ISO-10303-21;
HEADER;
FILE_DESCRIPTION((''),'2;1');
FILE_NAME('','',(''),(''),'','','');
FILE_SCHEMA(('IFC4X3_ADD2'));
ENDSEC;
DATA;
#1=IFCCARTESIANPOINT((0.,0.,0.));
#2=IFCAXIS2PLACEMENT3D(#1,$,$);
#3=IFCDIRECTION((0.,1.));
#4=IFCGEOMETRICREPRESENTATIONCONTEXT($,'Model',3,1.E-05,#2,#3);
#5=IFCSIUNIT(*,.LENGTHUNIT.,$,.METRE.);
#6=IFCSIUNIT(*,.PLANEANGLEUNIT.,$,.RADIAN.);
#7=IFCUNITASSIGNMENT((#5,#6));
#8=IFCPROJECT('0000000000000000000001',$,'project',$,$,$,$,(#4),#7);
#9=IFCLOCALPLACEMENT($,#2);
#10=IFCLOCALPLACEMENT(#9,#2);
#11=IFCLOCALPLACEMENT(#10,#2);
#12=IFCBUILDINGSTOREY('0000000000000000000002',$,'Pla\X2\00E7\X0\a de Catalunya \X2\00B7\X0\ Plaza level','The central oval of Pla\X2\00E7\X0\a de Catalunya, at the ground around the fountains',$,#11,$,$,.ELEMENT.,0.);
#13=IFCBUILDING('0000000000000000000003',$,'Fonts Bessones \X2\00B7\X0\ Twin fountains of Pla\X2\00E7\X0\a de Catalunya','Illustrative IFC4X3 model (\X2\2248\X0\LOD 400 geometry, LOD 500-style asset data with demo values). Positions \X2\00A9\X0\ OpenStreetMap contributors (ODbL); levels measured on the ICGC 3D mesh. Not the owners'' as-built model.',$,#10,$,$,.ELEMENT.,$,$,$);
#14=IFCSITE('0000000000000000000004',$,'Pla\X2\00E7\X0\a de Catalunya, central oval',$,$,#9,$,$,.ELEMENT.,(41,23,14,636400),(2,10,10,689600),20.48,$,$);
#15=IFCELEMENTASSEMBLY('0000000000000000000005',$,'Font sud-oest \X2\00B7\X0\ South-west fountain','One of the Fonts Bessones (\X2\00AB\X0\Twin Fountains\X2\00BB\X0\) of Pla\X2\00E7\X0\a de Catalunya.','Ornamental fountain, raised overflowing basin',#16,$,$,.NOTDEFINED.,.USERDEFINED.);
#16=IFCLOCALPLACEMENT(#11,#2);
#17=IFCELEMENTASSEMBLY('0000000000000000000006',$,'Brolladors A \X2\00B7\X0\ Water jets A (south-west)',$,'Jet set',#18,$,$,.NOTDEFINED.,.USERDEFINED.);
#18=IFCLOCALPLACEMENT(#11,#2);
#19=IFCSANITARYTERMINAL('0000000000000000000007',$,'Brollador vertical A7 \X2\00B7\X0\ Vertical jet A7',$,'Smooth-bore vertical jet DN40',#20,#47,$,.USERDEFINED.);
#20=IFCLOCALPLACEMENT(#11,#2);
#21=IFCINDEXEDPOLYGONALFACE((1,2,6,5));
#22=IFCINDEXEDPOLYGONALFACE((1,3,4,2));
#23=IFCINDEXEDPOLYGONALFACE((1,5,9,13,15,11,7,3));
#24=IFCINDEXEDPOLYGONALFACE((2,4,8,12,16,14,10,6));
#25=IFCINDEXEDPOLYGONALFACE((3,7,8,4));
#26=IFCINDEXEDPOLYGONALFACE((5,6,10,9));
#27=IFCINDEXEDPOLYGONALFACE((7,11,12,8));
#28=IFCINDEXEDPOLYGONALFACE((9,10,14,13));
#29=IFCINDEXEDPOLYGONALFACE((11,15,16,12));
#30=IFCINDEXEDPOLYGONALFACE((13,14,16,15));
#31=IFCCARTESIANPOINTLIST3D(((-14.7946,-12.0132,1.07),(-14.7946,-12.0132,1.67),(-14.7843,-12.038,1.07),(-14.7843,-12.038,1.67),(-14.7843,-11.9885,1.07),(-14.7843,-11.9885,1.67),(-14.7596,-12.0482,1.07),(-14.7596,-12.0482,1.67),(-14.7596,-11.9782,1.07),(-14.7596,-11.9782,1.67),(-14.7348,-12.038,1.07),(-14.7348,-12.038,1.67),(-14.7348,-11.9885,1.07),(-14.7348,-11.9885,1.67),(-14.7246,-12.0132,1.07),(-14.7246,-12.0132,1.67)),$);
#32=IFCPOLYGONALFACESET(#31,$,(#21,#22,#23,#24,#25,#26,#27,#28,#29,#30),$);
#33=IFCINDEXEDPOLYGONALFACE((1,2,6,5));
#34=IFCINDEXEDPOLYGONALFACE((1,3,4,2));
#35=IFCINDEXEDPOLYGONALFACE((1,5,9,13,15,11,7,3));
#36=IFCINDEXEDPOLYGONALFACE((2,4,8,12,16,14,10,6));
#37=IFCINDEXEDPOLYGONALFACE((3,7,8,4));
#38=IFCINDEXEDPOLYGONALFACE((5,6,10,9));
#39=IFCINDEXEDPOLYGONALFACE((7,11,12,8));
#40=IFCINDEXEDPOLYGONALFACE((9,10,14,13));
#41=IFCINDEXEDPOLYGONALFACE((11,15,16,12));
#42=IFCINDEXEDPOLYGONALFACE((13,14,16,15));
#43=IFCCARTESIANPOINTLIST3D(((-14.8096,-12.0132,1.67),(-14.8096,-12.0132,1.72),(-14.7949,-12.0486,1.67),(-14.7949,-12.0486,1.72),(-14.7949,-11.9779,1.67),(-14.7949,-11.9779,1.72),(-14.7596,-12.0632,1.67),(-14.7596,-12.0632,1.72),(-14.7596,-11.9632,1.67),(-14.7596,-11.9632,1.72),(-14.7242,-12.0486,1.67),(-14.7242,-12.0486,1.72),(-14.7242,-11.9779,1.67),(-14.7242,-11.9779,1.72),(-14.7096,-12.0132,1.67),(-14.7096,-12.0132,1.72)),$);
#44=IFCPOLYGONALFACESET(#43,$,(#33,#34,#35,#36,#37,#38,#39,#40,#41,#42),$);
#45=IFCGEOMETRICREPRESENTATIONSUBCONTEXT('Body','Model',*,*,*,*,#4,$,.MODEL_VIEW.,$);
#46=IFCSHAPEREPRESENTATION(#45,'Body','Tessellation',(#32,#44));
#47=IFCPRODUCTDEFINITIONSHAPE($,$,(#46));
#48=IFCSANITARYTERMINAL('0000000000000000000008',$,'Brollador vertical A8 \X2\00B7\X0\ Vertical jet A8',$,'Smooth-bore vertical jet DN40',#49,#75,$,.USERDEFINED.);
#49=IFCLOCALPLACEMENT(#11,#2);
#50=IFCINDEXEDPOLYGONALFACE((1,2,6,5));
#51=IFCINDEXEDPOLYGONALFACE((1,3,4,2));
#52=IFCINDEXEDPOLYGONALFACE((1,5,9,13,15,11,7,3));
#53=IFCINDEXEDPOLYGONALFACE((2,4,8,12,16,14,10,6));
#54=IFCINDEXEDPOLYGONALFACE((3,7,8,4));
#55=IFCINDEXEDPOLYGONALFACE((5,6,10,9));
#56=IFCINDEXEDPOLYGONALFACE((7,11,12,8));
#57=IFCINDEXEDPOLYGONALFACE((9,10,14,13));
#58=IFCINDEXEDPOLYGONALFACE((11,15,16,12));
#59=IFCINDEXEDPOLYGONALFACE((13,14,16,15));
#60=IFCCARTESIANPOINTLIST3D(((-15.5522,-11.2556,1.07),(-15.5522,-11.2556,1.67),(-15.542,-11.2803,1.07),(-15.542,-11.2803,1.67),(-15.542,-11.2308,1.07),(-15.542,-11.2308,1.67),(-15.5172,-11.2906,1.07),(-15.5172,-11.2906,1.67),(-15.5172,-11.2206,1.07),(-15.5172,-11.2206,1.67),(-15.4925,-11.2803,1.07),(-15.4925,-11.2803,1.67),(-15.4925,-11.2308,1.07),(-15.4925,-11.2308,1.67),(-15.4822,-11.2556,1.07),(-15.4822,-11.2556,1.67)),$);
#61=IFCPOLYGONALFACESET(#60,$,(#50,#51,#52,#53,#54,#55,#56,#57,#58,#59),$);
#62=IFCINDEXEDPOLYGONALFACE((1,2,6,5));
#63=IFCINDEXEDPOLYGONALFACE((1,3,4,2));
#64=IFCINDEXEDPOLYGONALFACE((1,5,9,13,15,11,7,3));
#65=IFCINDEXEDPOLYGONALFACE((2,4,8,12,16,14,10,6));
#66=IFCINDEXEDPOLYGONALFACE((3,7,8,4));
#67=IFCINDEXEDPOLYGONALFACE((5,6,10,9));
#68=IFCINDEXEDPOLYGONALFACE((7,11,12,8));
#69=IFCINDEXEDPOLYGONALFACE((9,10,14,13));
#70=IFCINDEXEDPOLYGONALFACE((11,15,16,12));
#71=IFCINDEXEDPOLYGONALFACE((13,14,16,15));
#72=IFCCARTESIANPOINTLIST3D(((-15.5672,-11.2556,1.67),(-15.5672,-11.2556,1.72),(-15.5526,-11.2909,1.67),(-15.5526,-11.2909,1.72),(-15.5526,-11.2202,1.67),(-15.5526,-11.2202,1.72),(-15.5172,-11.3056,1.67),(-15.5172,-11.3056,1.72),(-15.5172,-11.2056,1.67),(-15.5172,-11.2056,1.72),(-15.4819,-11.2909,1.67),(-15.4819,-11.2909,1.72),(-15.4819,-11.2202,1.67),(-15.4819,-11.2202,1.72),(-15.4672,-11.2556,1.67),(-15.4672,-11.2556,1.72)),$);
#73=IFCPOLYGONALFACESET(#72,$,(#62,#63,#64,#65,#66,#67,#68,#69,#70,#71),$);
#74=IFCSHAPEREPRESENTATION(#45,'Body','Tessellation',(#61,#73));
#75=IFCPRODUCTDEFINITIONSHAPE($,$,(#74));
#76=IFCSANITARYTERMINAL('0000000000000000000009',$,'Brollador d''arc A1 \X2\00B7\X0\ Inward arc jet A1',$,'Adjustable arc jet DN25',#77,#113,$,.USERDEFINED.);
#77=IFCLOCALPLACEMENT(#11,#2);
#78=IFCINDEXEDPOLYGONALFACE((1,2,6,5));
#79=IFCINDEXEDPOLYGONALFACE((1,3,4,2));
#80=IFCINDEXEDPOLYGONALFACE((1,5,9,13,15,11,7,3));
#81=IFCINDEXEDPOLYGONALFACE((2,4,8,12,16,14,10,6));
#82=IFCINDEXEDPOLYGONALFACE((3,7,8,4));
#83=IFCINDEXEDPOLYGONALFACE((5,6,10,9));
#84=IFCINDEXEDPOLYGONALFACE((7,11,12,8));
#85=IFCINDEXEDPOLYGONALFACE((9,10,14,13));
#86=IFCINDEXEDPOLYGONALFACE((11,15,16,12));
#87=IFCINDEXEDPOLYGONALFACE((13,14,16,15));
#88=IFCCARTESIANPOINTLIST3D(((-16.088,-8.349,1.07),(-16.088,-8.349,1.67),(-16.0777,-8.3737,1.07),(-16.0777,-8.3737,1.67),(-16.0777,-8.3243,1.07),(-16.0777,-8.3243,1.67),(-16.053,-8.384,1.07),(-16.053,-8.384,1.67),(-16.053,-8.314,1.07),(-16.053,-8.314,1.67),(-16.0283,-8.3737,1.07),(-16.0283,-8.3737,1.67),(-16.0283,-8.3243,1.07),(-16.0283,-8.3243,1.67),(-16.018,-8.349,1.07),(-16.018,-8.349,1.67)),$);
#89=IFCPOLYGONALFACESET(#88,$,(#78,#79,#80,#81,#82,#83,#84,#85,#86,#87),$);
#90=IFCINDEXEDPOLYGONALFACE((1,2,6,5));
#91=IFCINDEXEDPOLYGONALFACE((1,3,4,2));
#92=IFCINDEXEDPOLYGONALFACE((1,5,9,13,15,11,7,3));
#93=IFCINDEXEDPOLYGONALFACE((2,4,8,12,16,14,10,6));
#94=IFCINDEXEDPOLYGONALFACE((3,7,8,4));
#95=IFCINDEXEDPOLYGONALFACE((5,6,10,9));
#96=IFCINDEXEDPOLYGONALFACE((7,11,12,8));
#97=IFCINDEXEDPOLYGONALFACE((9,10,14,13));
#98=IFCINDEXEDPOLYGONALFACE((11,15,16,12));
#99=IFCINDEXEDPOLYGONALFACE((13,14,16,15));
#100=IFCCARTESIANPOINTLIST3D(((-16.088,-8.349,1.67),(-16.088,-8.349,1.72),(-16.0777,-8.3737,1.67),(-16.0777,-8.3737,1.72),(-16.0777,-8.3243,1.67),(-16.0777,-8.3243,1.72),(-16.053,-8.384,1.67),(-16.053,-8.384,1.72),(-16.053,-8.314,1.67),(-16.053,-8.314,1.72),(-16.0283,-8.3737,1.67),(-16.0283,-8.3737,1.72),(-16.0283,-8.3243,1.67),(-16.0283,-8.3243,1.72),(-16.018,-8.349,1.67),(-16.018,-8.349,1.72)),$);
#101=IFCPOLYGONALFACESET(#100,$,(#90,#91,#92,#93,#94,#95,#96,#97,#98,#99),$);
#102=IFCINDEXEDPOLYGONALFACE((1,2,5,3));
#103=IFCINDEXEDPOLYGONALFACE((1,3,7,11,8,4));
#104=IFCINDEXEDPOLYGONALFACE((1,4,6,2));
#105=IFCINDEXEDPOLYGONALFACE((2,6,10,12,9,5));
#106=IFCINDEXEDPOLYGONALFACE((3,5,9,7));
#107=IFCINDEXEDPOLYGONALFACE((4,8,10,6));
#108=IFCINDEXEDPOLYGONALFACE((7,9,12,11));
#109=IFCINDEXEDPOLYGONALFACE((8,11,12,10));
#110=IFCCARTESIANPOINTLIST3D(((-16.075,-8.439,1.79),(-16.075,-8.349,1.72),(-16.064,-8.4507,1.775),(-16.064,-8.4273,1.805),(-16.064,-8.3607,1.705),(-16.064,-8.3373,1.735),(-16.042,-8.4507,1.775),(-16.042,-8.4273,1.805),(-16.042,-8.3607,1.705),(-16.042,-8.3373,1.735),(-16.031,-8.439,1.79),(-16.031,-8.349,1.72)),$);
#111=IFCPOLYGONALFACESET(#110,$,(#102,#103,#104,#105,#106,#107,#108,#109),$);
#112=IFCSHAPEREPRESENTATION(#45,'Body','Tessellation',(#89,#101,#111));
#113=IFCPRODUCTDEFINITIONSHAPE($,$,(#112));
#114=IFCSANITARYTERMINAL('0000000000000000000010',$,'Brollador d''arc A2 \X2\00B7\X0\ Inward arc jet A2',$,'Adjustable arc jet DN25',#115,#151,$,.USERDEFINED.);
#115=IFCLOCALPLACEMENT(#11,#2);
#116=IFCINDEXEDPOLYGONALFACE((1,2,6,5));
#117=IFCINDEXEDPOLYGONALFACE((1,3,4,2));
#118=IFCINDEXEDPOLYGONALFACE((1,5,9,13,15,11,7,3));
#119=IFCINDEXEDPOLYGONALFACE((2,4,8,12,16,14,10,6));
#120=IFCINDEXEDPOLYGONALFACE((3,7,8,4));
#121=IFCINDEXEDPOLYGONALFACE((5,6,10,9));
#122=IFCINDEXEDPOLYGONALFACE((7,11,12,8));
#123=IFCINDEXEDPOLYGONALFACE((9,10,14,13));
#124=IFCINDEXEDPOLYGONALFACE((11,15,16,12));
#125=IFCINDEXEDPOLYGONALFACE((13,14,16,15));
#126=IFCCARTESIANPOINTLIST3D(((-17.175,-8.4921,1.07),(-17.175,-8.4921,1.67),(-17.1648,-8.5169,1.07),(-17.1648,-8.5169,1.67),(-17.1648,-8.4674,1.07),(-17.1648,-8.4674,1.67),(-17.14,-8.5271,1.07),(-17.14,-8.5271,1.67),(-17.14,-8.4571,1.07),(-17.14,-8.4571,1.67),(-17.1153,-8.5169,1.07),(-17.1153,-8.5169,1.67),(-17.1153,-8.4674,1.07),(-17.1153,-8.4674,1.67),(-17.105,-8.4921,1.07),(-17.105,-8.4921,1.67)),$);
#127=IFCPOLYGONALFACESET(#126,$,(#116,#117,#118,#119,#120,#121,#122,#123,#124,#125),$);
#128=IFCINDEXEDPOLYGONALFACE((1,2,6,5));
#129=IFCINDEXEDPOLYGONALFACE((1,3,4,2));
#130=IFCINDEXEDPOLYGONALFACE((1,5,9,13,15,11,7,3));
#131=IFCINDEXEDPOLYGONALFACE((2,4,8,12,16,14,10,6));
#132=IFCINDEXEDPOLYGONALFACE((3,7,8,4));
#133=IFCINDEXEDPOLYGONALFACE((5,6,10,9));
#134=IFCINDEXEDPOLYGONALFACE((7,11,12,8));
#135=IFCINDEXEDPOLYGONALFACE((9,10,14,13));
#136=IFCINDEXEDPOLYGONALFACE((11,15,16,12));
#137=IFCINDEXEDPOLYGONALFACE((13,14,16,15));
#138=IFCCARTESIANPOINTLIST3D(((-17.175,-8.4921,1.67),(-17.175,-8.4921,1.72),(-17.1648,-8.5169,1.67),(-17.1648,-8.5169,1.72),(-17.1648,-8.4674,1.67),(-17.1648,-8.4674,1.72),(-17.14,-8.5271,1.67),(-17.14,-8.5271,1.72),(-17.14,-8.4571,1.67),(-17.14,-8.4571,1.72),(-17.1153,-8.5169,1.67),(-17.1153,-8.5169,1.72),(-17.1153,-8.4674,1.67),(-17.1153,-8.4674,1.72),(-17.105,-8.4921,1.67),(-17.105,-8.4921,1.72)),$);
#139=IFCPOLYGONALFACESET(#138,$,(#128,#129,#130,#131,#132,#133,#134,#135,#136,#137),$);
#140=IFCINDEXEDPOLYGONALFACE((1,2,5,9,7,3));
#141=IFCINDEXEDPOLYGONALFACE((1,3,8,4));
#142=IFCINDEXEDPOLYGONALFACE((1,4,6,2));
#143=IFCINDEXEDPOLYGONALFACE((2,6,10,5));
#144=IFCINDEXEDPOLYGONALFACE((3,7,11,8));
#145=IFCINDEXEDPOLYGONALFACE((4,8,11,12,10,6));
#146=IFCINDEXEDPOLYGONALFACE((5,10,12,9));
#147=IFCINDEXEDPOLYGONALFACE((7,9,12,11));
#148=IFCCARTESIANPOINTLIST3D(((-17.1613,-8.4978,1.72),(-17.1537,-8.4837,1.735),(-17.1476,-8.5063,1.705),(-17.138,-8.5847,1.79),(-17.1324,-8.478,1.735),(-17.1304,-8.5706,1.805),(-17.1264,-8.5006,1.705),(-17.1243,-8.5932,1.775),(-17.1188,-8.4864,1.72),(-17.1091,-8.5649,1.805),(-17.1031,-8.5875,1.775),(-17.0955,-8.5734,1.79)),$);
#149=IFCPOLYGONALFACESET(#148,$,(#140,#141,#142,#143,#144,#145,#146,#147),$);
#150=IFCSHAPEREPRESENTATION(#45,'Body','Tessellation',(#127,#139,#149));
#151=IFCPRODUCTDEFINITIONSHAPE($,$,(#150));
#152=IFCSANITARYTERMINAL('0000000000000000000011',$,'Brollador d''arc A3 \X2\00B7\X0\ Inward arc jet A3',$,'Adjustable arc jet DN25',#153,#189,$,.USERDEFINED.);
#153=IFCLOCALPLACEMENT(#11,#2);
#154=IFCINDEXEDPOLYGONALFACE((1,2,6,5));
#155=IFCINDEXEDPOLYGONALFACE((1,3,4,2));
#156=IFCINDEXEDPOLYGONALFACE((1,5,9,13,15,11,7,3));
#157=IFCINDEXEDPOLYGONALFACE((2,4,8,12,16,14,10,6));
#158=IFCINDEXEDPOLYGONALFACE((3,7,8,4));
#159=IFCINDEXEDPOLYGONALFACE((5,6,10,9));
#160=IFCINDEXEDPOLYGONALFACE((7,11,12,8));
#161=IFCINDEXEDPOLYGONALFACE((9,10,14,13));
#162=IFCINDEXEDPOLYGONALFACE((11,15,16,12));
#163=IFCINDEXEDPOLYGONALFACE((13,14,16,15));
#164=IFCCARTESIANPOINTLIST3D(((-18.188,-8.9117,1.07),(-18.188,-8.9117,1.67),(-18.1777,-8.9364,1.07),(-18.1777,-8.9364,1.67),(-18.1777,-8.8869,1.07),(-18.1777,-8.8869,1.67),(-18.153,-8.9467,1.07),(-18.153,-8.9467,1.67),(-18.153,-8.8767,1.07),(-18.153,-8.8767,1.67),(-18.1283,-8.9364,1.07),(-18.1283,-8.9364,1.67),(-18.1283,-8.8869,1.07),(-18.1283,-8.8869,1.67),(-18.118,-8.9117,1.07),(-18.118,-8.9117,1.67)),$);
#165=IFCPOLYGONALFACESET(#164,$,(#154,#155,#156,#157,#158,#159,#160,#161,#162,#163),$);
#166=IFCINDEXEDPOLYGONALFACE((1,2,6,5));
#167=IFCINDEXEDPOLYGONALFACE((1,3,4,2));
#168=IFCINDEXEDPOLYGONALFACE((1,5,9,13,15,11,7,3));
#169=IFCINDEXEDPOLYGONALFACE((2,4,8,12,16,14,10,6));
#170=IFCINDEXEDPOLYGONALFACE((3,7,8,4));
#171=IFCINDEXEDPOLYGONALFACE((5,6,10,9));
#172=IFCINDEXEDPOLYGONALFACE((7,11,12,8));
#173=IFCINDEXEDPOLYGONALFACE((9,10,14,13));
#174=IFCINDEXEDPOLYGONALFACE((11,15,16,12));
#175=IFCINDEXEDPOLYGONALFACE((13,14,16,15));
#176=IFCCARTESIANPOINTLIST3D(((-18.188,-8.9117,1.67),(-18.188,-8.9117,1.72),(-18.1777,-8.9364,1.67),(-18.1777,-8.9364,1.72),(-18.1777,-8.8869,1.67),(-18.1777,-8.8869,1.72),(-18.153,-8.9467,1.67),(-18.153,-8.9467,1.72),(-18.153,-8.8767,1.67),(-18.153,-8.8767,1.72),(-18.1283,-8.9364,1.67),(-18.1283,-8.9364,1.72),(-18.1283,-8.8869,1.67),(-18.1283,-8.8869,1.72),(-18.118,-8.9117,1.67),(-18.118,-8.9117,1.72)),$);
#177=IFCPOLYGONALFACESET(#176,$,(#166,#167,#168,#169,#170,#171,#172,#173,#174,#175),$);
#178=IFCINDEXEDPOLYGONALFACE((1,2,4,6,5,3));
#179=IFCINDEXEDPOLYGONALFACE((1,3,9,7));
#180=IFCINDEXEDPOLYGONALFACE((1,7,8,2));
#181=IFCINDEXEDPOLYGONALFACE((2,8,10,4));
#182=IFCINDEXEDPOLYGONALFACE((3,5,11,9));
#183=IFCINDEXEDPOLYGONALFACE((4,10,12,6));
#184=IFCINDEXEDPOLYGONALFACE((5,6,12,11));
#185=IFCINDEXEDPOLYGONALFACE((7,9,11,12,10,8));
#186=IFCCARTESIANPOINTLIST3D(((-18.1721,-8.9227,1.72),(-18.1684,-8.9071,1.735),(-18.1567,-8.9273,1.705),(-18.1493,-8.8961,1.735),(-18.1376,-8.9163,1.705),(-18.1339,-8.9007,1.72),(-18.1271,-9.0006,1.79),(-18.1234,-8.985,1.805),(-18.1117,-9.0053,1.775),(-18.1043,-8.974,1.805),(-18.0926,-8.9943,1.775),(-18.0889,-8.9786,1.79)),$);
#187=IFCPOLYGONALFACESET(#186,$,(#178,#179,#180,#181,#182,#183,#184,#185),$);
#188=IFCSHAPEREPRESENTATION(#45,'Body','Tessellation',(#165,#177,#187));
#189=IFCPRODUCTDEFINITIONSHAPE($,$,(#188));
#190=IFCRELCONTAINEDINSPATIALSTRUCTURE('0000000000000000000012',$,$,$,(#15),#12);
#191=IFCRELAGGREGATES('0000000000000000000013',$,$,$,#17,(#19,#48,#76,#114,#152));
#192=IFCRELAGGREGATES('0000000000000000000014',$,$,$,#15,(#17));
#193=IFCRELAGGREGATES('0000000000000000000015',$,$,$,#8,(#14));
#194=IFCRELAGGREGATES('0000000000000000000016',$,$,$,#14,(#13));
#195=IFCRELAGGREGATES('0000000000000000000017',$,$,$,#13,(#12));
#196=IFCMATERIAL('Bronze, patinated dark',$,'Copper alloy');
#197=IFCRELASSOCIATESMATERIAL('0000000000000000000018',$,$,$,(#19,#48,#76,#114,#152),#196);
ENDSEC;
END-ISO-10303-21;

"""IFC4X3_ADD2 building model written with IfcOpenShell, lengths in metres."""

from ifc_helpers import new_model, si_unit, direction, frame, origin, place, context, subcontext, project, spatial, polyline, outline, extrude, material, element, aggregate, save


model = new_model("IFC4X3_ADD2")

# Units and contexts
model_context = context("Model", 3, precision=1e-05, world=origin(), true_north=direction((0.0, 1.0)))
body_context = subcontext(model_context, "Body", "Model", "MODEL_VIEW")
ifc_project = project(units=[si_unit("LENGTHUNIT", "METRE"), si_unit("PLANEANGLEUNIT", "RADIAN")], contexts=[model_context])

# Site, building, storey
site_placement = place(None, origin())
site = spatial("IfcSite", under=ifc_project, at=site_placement, Name="Plaça de Catalunya, central oval", CompositionType="ELEMENT", RefLatitude=(41, 23, 14, 636400), RefLongitude=(2, 10, 10, 689600), RefElevation=20.48)
building_placement = place(site_placement, origin())
building = spatial("IfcBuilding", under=site, at=building_placement, Name="Fonts Bessones · Twin fountains of Plaça de Catalunya", Description="Illustrative IFC4X3 model (≈LOD 400 geometry, LOD 500-style asset data with demo values). Positions © OpenStreetMap contributors (ODbL); levels measured on the ICGC 3D mesh. Not the owners' as-built model.", CompositionType="ELEMENT")
storey_placement = place(building_placement, origin())
storey = spatial("IfcBuildingStorey", under=building, at=storey_placement, Name="Plaça de Catalunya · Plaza level", Description="The central oval of Plaça de Catalunya, at the ground around the fountains", CompositionType="ELEMENT", Elevation=0.0)

# Element assemblies, sanitary terminals
assembly_1_placement = place(building_placement, origin())
assembly_1 = element("IfcElementAssembly", 1, at=assembly_1_placement, inside=storey, Name="Font sud-oest · South-west fountain", Description="One of the Fonts Bessones («Twin Fountains») of Plaça de Catalunya.", ObjectType="Ornamental fountain, raised overflowing basin", AssemblyPlace="NOTDEFINED", PredefinedType="USERDEFINED")
assembly_2_placement = place(building_placement, origin())
assembly_2 = element("IfcElementAssembly", 2, at=assembly_2_placement, Name="Brolladors A · Water jets A (south-west)", ObjectType="Jet set", AssemblyPlace="NOTDEFINED", PredefinedType="USERDEFINED")
ifc_material_1 = material(Name="Bronze, patinated dark", Category="Copper alloy")
sanitary_terminal_1_placement = place(building_placement, origin())
sanitary_terminal_1 = element("IfcSanitaryTerminal", 3, at=sanitary_terminal_1_placement, material=ifc_material_1, Name="Brollador vertical A7 · Vertical jet A7", ObjectType="Smooth-bore vertical jet DN40", PredefinedType="USERDEFINED", context=body_context, shape_type="SweptSolid", body=[
    extrude(outline(polyline([(-14.7246, -12.0132), (-14.7348, -11.9885), (-14.7596, -11.9782), (-14.7843, -11.9885), (-14.7946, -12.0132), (-14.7843, -12.038), (-14.7596, -12.0482), (-14.7348, -12.038), (-14.7246, -12.0132)])), frame((0.0, 0.0, 1.07)), (0.0, 0.0, 1.0), 0.6),
    extrude(outline(polyline([(-14.7096, -12.0132), (-14.7242, -11.9779), (-14.7596, -11.9632), (-14.7949, -11.9779), (-14.8096, -12.0132), (-14.7949, -12.0486), (-14.7596, -12.0632), (-14.7242, -12.0486), (-14.7096, -12.0132)])), frame((0.0, 0.0, 1.67)), (0.0, 0.0, 1.0), 0.05),
])
sanitary_terminal_2_placement = place(building_placement, origin())
sanitary_terminal_2 = element("IfcSanitaryTerminal", 4, at=sanitary_terminal_2_placement, material=ifc_material_1, Name="Brollador vertical A8 · Vertical jet A8", ObjectType="Smooth-bore vertical jet DN40", PredefinedType="USERDEFINED", context=body_context, shape_type="SweptSolid", body=[
    extrude(outline(polyline([(-15.4822, -11.2556), (-15.4925, -11.2308), (-15.5172, -11.2206), (-15.542, -11.2308), (-15.5522, -11.2556), (-15.542, -11.2803), (-15.5172, -11.2906), (-15.4925, -11.2803), (-15.4822, -11.2556)])), frame((0.0, 0.0, 1.07)), (0.0, 0.0, 1.0), 0.6),
    extrude(outline(polyline([(-15.4672, -11.2556), (-15.4819, -11.2202), (-15.5172, -11.2056), (-15.5526, -11.2202), (-15.5672, -11.2556), (-15.5526, -11.2909), (-15.5172, -11.3056), (-15.4819, -11.2909), (-15.4672, -11.2556)])), frame((0.0, 0.0, 1.67)), (0.0, 0.0, 1.0), 0.05),
])
sanitary_terminal_3_placement = place(building_placement, origin())
sanitary_terminal_3 = element("IfcSanitaryTerminal", 5, at=sanitary_terminal_3_placement, material=ifc_material_1, Name="Brollador d'arc A1 · Inward arc jet A1", ObjectType="Adjustable arc jet DN25", PredefinedType="USERDEFINED", context=body_context, shape_type="SweptSolid", body=[
    extrude(outline(polyline([(-16.018, -8.349), (-16.0283, -8.3243), (-16.053, -8.314), (-16.0777, -8.3243), (-16.088, -8.349), (-16.0777, -8.3737), (-16.053, -8.384), (-16.0283, -8.3737), (-16.018, -8.349)])), frame((0.0, 0.0, 1.07)), (0.0, 0.0, 1.0), 0.6),
    extrude(outline(polyline([(-16.018, -8.349), (-16.0283, -8.3243), (-16.053, -8.314), (-16.0777, -8.3243), (-16.088, -8.349), (-16.0777, -8.3737), (-16.053, -8.384), (-16.0283, -8.3737), (-16.018, -8.349)])), frame((0.0, 0.0, 1.67)), (0.0, 0.0, 1.0), 0.05),
    extrude(outline(polyline([(0.022, 0.0), (0.011, 0.0191), (-0.011, 0.0191), (-0.022, 0.0), (-0.011, -0.0191), (0.011, -0.0191), (0.022, 0.0)])), frame((-16.053, -8.349, 1.72), z_axis=(0.0, -0.789352, 0.613941), x_axis=(-1.0, 0.0, 0.0)), (0.0, 0.0, 1.0), 0.114),
])
sanitary_terminal_4_placement = place(building_placement, origin())
sanitary_terminal_4 = element("IfcSanitaryTerminal", 6, at=sanitary_terminal_4_placement, material=ifc_material_1, Name="Brollador d'arc A2 · Inward arc jet A2", ObjectType="Adjustable arc jet DN25", PredefinedType="USERDEFINED", context=body_context, shape_type="SweptSolid", body=[
    extrude(outline(polyline([(-17.105, -8.4921), (-17.1153, -8.4674), (-17.14, -8.4571), (-17.1648, -8.4674), (-17.175, -8.4921), (-17.1648, -8.5169), (-17.14, -8.5271), (-17.1153, -8.5169), (-17.105, -8.4921)])), frame((0.0, 0.0, 1.07)), (0.0, 0.0, 1.0), 0.6),
    extrude(outline(polyline([(-17.105, -8.4921), (-17.1153, -8.4674), (-17.14, -8.4571), (-17.1648, -8.4674), (-17.175, -8.4921), (-17.1648, -8.5169), (-17.14, -8.5271), (-17.1153, -8.5169), (-17.105, -8.4921)])), frame((0.0, 0.0, 1.67)), (0.0, 0.0, 1.0), 0.05),
    extrude(outline(polyline([(0.022, 0.0), (0.011, 0.0191), (-0.011, 0.0191), (-0.022, 0.0), (-0.011, -0.0191), (0.011, -0.0191), (0.022, 0.0)])), frame((-17.14, -8.4921, 1.72), z_axis=(0.204299, -0.762456, 0.613941), x_axis=(-0.965926, -0.258819, 0.0)), (0.0, 0.0, 1.0), 0.114),
])
sanitary_terminal_5_placement = place(building_placement, origin())
sanitary_terminal_5 = element("IfcSanitaryTerminal", 7, at=sanitary_terminal_5_placement, material=ifc_material_1, Name="Brollador d'arc A3 · Inward arc jet A3", ObjectType="Adjustable arc jet DN25", PredefinedType="USERDEFINED", context=body_context, shape_type="SweptSolid", body=[
    extrude(outline(polyline([(-18.118, -8.9117), (-18.1283, -8.8869), (-18.153, -8.8767), (-18.1777, -8.8869), (-18.188, -8.9117), (-18.1777, -8.9364), (-18.153, -8.9467), (-18.1283, -8.9364), (-18.118, -8.9117)])), frame((0.0, 0.0, 1.07)), (0.0, 0.0, 1.0), 0.6),
    extrude(outline(polyline([(-18.118, -8.9117), (-18.1283, -8.8869), (-18.153, -8.8767), (-18.1777, -8.8869), (-18.188, -8.9117), (-18.1777, -8.9364), (-18.153, -8.9467), (-18.1283, -8.9364), (-18.118, -8.9117)])), frame((0.0, 0.0, 1.67)), (0.0, 0.0, 1.0), 0.05),
    extrude(outline(polyline([(0.022, 0.0), (0.011, 0.0191), (-0.011, 0.0191), (-0.022, 0.0), (-0.011, -0.0191), (0.011, -0.0191), (0.022, 0.0)])), frame((-18.153, -8.9117, 1.72), z_axis=(0.394676, -0.683599, 0.613941), x_axis=(-0.866025, -0.5, 0.0)), (0.0, 0.0, 1.0), 0.114),
])
aggregate(assembly_2, [sanitary_terminal_1, sanitary_terminal_2, sanitary_terminal_3, sanitary_terminal_4, sanitary_terminal_5])
aggregate(assembly_1, [assembly_2])

save(model, "model.ifc")
